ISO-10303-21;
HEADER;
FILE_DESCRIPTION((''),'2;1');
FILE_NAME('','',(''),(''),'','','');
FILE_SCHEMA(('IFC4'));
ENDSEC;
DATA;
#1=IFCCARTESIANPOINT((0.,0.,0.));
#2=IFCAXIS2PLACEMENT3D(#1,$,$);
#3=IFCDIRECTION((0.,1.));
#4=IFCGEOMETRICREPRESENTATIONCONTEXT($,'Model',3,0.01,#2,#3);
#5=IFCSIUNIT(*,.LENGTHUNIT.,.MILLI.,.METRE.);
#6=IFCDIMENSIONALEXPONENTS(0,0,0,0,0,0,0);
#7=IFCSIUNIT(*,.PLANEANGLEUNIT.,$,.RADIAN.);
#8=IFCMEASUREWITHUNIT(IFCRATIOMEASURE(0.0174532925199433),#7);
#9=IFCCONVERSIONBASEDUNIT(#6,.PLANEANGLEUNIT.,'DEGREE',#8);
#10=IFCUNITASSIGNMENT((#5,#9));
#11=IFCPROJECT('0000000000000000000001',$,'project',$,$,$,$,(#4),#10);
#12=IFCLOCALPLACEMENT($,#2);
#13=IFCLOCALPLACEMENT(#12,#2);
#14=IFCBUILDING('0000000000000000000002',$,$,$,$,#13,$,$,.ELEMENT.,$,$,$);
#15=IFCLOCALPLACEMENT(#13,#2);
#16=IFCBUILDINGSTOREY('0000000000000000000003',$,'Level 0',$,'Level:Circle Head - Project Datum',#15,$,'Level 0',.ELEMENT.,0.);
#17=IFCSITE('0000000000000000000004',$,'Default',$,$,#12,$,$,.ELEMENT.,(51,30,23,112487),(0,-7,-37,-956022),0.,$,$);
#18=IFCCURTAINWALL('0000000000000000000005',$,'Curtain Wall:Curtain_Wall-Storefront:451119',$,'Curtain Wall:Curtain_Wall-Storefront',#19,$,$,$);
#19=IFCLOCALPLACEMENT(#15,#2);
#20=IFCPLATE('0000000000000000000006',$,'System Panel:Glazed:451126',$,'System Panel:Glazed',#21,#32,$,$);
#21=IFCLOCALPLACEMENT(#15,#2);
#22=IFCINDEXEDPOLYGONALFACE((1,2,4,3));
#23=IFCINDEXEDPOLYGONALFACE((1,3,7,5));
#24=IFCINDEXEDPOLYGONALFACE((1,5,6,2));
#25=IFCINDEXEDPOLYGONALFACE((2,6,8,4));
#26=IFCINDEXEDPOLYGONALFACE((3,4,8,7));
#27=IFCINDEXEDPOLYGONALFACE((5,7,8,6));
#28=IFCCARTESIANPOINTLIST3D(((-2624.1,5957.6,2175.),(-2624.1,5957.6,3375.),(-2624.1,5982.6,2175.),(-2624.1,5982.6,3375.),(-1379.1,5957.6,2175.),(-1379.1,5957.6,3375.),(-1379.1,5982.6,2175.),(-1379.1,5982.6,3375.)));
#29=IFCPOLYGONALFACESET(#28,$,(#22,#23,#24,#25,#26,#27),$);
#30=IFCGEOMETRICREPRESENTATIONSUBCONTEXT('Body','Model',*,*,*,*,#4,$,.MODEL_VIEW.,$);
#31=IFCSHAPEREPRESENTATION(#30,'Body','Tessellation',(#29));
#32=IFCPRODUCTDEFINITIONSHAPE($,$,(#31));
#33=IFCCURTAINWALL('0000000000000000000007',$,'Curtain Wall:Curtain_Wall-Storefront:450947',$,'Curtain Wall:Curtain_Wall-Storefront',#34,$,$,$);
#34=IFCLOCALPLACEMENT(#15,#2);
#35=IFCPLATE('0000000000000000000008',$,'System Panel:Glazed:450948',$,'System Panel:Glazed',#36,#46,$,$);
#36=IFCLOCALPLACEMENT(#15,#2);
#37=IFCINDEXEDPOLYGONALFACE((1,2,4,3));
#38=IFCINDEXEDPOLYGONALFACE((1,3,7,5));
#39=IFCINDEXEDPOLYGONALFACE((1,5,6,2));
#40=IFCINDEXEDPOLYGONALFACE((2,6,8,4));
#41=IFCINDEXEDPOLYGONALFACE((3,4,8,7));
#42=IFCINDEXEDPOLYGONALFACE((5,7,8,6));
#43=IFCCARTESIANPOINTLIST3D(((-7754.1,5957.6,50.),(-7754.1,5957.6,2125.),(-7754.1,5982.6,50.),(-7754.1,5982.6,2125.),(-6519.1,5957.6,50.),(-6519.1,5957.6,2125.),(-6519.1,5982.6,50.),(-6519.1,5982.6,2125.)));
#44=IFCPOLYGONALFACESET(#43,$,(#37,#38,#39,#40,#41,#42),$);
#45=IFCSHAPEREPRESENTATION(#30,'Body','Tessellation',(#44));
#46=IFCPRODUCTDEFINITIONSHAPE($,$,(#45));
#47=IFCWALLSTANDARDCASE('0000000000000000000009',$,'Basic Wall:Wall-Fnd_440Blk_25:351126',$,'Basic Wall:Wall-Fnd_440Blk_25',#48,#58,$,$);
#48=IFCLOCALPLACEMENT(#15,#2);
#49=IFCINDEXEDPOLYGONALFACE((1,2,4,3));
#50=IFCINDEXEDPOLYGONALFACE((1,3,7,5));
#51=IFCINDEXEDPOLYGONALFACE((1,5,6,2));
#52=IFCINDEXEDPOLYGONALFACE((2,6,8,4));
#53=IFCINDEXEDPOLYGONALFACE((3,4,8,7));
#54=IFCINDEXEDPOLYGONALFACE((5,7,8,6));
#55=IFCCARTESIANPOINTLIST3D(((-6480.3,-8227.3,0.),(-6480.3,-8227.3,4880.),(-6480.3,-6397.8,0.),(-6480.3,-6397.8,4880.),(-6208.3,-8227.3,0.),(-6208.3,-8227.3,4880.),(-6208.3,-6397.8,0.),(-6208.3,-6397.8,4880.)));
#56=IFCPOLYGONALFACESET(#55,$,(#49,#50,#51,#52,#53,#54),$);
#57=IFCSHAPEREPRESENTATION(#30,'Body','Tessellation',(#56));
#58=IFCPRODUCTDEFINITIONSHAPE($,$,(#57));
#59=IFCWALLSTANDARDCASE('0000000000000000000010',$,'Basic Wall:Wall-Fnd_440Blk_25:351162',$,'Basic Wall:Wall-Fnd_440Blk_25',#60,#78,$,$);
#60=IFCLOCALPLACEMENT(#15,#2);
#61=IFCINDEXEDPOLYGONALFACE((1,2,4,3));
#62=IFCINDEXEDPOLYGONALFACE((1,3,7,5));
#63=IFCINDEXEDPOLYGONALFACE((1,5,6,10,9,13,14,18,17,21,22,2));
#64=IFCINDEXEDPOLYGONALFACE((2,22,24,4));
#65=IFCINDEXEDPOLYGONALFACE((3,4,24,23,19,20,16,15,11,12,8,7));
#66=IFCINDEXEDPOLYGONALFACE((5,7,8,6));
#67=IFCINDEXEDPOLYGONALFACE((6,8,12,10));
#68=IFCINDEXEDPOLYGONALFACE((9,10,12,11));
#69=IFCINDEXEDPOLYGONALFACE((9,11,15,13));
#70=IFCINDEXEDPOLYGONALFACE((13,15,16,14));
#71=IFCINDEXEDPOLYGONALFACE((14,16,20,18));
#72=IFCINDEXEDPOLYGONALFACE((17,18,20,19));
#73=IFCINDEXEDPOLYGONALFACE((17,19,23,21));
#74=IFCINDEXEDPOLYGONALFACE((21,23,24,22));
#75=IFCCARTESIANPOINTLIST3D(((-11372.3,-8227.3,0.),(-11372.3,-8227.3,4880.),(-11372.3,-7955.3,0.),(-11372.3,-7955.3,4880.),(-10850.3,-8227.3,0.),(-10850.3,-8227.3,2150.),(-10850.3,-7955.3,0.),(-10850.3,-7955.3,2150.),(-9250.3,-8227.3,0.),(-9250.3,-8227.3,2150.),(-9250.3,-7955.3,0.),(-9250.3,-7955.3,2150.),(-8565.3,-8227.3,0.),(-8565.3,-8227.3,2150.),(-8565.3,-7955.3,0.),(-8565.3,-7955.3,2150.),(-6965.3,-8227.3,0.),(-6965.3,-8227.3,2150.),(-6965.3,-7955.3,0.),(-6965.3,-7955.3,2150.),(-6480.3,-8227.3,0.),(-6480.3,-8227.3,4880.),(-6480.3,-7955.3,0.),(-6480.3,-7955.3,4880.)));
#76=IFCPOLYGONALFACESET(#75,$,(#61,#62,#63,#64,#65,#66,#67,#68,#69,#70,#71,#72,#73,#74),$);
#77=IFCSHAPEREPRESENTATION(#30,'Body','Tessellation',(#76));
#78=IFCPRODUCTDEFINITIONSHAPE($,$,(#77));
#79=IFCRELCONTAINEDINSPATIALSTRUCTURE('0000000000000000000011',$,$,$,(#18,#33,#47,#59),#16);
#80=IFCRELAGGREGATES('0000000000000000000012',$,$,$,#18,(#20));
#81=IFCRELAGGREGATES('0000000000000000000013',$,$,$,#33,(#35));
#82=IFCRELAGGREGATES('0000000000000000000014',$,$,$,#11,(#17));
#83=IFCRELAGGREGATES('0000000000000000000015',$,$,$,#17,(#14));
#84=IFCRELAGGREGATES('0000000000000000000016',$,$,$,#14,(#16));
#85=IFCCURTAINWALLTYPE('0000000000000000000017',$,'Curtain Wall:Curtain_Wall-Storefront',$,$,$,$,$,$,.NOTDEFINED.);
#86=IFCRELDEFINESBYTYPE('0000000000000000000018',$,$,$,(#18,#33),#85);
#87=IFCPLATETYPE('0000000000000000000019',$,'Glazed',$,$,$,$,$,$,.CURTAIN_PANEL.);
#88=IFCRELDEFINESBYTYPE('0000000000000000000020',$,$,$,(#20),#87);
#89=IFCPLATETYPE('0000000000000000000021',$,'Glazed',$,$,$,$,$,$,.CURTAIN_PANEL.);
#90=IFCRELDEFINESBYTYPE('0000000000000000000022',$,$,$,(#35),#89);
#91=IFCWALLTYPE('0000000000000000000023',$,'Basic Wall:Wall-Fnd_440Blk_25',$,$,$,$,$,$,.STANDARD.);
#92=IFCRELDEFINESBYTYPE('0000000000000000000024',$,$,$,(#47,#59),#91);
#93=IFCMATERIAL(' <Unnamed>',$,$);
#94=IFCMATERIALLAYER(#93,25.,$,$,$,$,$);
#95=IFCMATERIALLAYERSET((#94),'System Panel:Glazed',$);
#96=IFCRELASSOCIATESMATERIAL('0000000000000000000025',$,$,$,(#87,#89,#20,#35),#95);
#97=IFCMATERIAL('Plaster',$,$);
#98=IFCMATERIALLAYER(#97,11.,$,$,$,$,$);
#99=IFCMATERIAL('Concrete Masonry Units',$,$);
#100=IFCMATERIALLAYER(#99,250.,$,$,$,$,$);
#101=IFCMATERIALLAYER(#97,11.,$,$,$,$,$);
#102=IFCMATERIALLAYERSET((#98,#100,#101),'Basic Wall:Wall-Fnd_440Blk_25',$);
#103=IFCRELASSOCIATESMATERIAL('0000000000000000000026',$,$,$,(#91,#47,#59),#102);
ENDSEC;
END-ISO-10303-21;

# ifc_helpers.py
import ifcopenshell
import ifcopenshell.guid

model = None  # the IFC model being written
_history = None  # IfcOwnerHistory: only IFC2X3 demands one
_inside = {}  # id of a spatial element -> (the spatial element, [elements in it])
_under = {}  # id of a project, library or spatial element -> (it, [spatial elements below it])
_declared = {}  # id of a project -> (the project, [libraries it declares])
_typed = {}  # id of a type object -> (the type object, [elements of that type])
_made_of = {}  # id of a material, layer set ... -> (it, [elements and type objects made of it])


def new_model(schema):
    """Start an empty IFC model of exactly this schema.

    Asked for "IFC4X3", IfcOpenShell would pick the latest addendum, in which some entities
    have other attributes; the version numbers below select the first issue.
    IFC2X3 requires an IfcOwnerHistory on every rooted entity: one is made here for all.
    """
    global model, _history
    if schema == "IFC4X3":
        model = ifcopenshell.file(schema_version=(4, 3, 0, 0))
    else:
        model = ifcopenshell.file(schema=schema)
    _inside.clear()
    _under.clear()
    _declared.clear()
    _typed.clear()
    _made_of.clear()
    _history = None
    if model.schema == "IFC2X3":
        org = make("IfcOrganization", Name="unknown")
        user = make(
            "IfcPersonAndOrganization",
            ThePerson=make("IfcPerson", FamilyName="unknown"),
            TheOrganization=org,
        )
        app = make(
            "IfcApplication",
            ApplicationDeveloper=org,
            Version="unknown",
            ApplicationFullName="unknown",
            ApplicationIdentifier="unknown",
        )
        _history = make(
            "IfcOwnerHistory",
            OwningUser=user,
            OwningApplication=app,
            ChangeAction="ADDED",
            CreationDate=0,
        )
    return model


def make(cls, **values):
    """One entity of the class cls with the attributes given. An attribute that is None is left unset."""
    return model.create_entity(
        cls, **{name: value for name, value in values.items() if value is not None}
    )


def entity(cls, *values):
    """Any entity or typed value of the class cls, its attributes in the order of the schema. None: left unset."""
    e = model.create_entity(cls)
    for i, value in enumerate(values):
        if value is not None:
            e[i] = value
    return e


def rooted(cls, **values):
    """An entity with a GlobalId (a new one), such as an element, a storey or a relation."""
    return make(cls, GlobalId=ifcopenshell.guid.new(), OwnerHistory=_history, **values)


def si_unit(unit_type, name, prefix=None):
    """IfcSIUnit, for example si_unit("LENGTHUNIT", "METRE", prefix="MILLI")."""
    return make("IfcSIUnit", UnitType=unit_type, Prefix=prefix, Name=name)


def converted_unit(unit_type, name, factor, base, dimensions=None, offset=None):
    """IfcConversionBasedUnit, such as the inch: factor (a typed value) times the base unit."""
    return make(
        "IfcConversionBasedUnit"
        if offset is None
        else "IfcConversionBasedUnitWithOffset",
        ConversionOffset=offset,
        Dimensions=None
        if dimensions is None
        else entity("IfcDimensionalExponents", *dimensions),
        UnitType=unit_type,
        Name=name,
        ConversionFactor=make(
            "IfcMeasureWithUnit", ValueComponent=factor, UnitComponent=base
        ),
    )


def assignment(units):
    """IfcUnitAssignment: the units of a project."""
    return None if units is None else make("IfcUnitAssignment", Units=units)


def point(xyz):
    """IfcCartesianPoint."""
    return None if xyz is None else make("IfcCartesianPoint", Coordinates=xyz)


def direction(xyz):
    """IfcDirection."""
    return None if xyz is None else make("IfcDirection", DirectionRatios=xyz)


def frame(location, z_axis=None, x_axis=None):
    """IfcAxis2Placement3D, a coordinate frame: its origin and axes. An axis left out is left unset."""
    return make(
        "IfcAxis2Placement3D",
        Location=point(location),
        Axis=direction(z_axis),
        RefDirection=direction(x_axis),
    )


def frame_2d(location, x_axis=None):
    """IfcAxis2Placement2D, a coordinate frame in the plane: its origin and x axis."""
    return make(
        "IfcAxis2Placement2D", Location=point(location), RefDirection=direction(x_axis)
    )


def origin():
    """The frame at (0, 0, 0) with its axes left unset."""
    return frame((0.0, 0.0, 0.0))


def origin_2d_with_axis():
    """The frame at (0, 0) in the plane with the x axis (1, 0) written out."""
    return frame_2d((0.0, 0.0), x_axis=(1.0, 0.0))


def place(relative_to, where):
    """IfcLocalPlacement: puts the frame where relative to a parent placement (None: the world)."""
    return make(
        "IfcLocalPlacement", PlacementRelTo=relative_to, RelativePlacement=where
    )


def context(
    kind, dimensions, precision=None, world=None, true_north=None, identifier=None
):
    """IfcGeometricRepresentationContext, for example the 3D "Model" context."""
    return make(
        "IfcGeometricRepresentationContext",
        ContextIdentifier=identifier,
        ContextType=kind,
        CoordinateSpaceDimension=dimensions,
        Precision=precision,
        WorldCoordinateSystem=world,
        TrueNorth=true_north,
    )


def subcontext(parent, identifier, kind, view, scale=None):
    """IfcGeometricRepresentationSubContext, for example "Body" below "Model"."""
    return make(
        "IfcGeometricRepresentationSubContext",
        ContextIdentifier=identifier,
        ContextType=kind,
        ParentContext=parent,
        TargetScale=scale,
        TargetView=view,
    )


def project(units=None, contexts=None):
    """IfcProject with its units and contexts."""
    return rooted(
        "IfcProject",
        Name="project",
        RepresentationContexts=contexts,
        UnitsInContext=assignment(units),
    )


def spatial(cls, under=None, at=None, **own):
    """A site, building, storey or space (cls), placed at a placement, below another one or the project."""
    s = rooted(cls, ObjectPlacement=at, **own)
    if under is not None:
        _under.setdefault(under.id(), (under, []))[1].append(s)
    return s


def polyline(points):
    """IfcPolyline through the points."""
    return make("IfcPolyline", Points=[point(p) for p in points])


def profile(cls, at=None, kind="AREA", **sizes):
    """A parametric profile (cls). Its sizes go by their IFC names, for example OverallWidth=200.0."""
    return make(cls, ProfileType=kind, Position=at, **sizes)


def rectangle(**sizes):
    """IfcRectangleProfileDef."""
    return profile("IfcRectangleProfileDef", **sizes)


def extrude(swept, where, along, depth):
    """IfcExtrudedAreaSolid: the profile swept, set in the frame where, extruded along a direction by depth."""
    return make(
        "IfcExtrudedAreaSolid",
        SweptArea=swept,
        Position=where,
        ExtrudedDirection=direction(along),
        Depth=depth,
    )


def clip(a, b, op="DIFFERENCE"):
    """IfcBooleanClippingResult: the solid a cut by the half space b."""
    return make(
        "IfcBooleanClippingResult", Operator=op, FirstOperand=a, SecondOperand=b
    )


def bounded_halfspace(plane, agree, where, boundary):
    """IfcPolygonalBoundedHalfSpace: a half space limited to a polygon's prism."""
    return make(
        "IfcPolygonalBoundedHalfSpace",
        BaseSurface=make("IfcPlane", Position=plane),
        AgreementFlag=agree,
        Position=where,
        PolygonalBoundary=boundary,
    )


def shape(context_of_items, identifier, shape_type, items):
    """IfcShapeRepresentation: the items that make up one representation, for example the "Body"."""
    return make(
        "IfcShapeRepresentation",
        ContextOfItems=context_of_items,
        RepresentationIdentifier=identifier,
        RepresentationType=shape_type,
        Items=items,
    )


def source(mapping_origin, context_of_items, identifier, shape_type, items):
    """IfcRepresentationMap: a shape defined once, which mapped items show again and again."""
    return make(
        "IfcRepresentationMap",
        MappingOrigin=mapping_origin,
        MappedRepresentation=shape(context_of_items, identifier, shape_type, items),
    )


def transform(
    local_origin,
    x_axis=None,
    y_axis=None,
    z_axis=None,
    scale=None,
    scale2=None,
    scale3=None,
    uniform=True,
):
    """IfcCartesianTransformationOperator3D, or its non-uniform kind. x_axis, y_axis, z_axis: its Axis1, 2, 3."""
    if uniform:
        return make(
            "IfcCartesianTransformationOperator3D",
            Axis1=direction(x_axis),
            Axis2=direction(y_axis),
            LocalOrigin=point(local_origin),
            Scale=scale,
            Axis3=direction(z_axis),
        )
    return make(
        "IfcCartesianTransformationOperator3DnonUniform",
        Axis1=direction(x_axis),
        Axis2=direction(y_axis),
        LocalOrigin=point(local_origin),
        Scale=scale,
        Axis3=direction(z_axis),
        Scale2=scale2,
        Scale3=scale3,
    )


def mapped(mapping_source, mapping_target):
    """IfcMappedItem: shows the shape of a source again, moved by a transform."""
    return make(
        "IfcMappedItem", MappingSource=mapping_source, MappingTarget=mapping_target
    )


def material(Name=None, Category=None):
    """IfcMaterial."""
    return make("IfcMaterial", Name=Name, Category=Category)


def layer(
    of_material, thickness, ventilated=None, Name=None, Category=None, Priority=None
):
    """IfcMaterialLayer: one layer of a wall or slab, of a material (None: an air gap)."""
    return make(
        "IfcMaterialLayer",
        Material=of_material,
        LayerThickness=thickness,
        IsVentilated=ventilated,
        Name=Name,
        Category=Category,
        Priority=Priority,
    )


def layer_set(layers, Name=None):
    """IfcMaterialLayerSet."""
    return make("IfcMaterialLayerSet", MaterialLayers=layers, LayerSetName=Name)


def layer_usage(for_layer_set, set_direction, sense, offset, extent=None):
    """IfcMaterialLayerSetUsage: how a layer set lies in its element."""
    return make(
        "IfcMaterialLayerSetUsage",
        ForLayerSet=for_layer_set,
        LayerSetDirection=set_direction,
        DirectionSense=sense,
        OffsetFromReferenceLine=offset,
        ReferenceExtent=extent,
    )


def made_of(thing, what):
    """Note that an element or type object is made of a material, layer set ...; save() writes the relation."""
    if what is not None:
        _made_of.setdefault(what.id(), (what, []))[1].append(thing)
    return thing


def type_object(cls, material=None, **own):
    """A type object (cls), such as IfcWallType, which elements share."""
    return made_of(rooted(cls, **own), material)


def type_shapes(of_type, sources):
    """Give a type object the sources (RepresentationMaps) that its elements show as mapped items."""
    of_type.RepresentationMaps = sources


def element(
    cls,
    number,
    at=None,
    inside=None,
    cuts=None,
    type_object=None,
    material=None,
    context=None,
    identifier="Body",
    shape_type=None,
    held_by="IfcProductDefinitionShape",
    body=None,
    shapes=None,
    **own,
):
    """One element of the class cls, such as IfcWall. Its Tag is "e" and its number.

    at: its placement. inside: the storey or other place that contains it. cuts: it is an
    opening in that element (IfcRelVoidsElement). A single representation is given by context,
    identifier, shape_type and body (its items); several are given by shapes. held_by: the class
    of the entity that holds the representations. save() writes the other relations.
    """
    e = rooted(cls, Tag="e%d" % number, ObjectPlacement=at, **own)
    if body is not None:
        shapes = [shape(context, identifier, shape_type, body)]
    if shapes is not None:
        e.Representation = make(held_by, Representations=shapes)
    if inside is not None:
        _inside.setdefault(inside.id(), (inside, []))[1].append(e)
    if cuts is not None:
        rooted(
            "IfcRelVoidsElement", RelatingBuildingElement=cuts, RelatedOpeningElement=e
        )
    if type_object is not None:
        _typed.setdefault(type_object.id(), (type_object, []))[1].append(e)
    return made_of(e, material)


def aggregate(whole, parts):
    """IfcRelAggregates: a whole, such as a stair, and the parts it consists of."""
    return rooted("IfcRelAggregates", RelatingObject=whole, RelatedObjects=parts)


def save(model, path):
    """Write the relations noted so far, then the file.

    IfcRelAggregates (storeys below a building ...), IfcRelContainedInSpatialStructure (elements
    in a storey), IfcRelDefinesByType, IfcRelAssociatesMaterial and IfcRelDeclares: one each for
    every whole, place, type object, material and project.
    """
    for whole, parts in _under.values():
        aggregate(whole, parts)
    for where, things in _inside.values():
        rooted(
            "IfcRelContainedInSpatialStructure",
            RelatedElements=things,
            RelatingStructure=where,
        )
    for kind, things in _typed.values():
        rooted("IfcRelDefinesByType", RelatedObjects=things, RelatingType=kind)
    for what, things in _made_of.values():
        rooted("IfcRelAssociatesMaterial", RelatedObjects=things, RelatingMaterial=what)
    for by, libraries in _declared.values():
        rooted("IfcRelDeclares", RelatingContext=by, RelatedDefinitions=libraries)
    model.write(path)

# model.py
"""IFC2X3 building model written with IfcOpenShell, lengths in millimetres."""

from ifc_helpers import new_model, entity, si_unit, converted_unit, direction, frame, frame_2d, origin, origin_2d_with_axis, place, context, subcontext, project, spatial, polyline, rectangle, extrude, clip, bounded_halfspace, source, transform, mapped, material, layer, layer_set, layer_usage, type_object, type_shapes, element, aggregate, save


model = new_model("IFC2X3")

# Units and contexts
model_context = context("Model", 3, precision=0.01, world=origin(), true_north=direction((0.0, 1.0)))
body_context = subcontext(model_context, "Body", "Model", "MODEL_VIEW")
ifc_project = project(units=[si_unit("LENGTHUNIT", "METRE", prefix="MILLI"), converted_unit("PLANEANGLEUNIT", "DEGREE", entity("IfcRatioMeasure", 0.0174532925199433), si_unit("PLANEANGLEUNIT", "RADIAN"), dimensions=[0, 0, 0, 0, 0, 0, 0])], contexts=[model_context])

# Site, building, storey
site_placement = place(None, origin())
site = spatial("IfcSite", under=ifc_project, at=site_placement, Name="Default", CompositionType="ELEMENT", RefLatitude=(51, 30, 23, 112487), RefLongitude=(0, -7, -37, -956022), RefElevation=0.0)
building_placement = place(site_placement, origin())
building = spatial("IfcBuilding", under=site, at=building_placement, CompositionType="ELEMENT")
storey_placement = place(building_placement, origin())
storey = spatial("IfcBuildingStorey", under=building, at=storey_placement, Name="Level 0", ObjectType="Level:Circle Head - Project Datum", LongName="Level 0", CompositionType="ELEMENT", Elevation=0.0)

# Shared definitions
ifc_material_1 = material(Name="Plaster")

# Curtain wall
curtain_wall_type = type_object("IfcCurtainWallType", Name="Curtain Wall:Curtain_Wall-Storefront", PredefinedType="NOTDEFINED")
curtain_wall_1_placement = place(storey_placement, origin())
curtain_wall_1 = element("IfcCurtainWall", 1, at=curtain_wall_1_placement, inside=storey, type_object=curtain_wall_type, Name="Curtain Wall:Curtain_Wall-Storefront:451119", ObjectType="Curtain Wall:Curtain_Wall-Storefront")

# Plate
ifc_material_2 = material(Name=" <Unnamed>")
ifc_layer_1 = layer(ifc_material_2, 25.0)
ifc_layer_set_1 = layer_set([ifc_layer_1], Name="System Panel:Glazed")
ifc_layer_usage_1 = layer_usage(ifc_layer_set_1, "AXIS3", "POSITIVE", 0.2)
plate_type_1 = type_object("IfcPlateType", Name="Glazed", PredefinedType="CURTAIN_PANEL", material=ifc_layer_set_1)
shared_shape_1 = source(origin(), body_context, "Body", "SweptSolid", [
    extrude(rectangle(XDim=25.0, YDim=1245.0, at=origin_2d_with_axis()), frame((0.0, 60.0, 0.0), z_axis=(0.0, 0.0, 1.0), x_axis=(0.0, 1.0, 0.0)), (0.0, 0.0, 1.0), 1200.0),
])
type_shapes(plate_type_1, [shared_shape_1])
plate_1_placement = place(curtain_wall_1_placement, frame((-2001.6, 6030.1, 2175.0), z_axis=(0.0, 0.0, 1.0), x_axis=(-1.0, 0.0, 0.0)))
plate_1 = element("IfcPlate", 2, at=plate_1_placement, type_object=plate_type_1, material=ifc_layer_usage_1, Name="System Panel:Glazed:451126", ObjectType="System Panel:Glazed", context=body_context, shape_type="MappedRepresentation", body=[
    mapped(shared_shape_1, transform((0.0, 0.0, 0.0), scale=1.0)),
])
aggregate(curtain_wall_1, [plate_1])

# Curtain wall, plate
curtain_wall_2_placement = place(storey_placement, origin())
curtain_wall_2 = element("IfcCurtainWall", 3, at=curtain_wall_2_placement, inside=storey, type_object=curtain_wall_type, Name="Curtain Wall:Curtain_Wall-Storefront:450947", ObjectType="Curtain Wall:Curtain_Wall-Storefront")
ifc_layer_usage_2 = layer_usage(ifc_layer_set_1, "AXIS3", "POSITIVE", 0.2)
plate_type_2 = type_object("IfcPlateType", Name="Glazed", PredefinedType="CURTAIN_PANEL", material=ifc_layer_set_1)
shared_shape_2 = source(origin(), body_context, "Body", "SweptSolid", [
    extrude(rectangle(XDim=25.0, YDim=1235.0, at=origin_2d_with_axis()), frame((0.0, 60.0, 0.0), z_axis=(0.0, 0.0, 1.0), x_axis=(0.0, 1.0, 0.0)), (0.0, 0.0, 1.0), 2075.0),
])
type_shapes(plate_type_2, [shared_shape_2])
plate_2_placement = place(curtain_wall_2_placement, frame((-7136.6, 6030.1, 50.0), z_axis=(0.0, 0.0, 1.0), x_axis=(-1.0, 0.0, 0.0)))
plate_2 = element("IfcPlate", 4, at=plate_2_placement, type_object=plate_type_2, material=ifc_layer_usage_2, Name="System Panel:Glazed:450948", ObjectType="System Panel:Glazed", context=body_context, shape_type="MappedRepresentation", body=[
    mapped(shared_shape_2, transform((0.0, 0.0, 0.0), scale=1.0)),
])
aggregate(curtain_wall_2, [plate_2])

# Shared definitions
ifc_material_3 = material(Name="Concrete Masonry Units")

# Wall
ifc_layer_2 = layer(ifc_material_1, 11.0)
ifc_layer_3 = layer(ifc_material_3, 250.0)
ifc_layer_4 = layer(ifc_material_1, 11.0)
ifc_layer_set_2 = layer_set([ifc_layer_2, ifc_layer_3, ifc_layer_4], Name="Basic Wall:Wall-Fnd_440Blk_25")
ifc_layer_usage_3 = layer_usage(ifc_layer_set_2, "AXIS2", "NEGATIVE", 136.0)
wall_type_1 = type_object("IfcWallType", Name="Basic Wall:Wall-Fnd_440Blk_25", PredefinedType="STANDARD", material=ifc_layer_set_2)
wall_1_placement = place(storey_placement, frame((-6344.3, -6397.8, 0.0), z_axis=(0.0, 0.0, 1.0), x_axis=(0.0, -1.0, 0.0)))
element("IfcWallStandardCase", 5, at=wall_1_placement, inside=storey, type_object=wall_type_1, material=ifc_layer_usage_3, Name="Basic Wall:Wall-Fnd_440Blk_25:351126", ObjectType="Basic Wall:Wall-Fnd_440Blk_25", context=body_context, shape_type="SweptSolid", body=[
    extrude(rectangle(XDim=1829.5, YDim=272.0, at=frame_2d((914.8, 0.0), x_axis=(-1.0, 0.0))), origin(), (0.0, 0.0, 1.0), 4880.0),
])

# Wall, openings
ifc_layer_usage_4 = layer_usage(ifc_layer_set_2, "AXIS2", "NEGATIVE", 136.0)
wall_2_placement = place(storey_placement, frame((-6480.3, -8091.3, 0.0), z_axis=(0.0, 0.0, 1.0), x_axis=(-1.0, 0.0, 0.0)))
wall_2 = element("IfcWallStandardCase", 6, at=wall_2_placement, inside=storey, type_object=wall_type_1, material=ifc_layer_usage_4, Name="Basic Wall:Wall-Fnd_440Blk_25:351162", ObjectType="Basic Wall:Wall-Fnd_440Blk_25", context=body_context, shape_type="Clipping", body=[
    clip(extrude(rectangle(XDim=4892.0, YDim=272.0, at=frame_2d((2446.0, 0.0), x_axis=(-1.0, 0.0))), origin(), (0.0, 0.0, 1.0), 4880.0), bounded_halfspace(frame((0.0, -136.0, 4880.0), z_axis=(0.0, 0.0, -1.0), x_axis=(-1.0, 0.0, 0.0)), True, frame((0.0, -136.0, 4880.0)), polyline([(0.0, 0.0), (4620.0, 0.0), (4892.0, 0.0), (4892.0, 272.0), (0.0, 272.0), (0.0, 0.0)]))),
])
opening_1_placement = place(wall_2_placement, frame((2085.0, 136.0, 0.0)))
element("IfcOpeningElement", 7, at=opening_1_placement, cuts=wall_2, ObjectType="Opening", context=body_context, shape_type="SweptSolid", body=[
    extrude(rectangle(XDim=2150.0, YDim=1600.0, at=frame_2d((1075.0, 800.0), x_axis=(1.0, 0.0))), frame((0.0, 0.0, 0.0), z_axis=(0.0, -1.0, 0.0), x_axis=(0.0, 0.0, 1.0)), (0.0, 0.0, 1.0), 272.0),
])
opening_2_placement = place(wall_2_placement, frame((4370.0, 136.0, 0.0)))
element("IfcOpeningElement", 8, at=opening_2_placement, cuts=wall_2, ObjectType="Opening", context=body_context, shape_type="SweptSolid", body=[
    extrude(rectangle(XDim=2150.0, YDim=1600.0, at=frame_2d((1075.0, 800.0), x_axis=(1.0, 0.0))), frame((0.0, 0.0, 0.0), z_axis=(0.0, -1.0, 0.0), x_axis=(0.0, 0.0, 1.0)), (0.0, 0.0, 1.0), 272.0),
])

save(model, "model.ifc")
